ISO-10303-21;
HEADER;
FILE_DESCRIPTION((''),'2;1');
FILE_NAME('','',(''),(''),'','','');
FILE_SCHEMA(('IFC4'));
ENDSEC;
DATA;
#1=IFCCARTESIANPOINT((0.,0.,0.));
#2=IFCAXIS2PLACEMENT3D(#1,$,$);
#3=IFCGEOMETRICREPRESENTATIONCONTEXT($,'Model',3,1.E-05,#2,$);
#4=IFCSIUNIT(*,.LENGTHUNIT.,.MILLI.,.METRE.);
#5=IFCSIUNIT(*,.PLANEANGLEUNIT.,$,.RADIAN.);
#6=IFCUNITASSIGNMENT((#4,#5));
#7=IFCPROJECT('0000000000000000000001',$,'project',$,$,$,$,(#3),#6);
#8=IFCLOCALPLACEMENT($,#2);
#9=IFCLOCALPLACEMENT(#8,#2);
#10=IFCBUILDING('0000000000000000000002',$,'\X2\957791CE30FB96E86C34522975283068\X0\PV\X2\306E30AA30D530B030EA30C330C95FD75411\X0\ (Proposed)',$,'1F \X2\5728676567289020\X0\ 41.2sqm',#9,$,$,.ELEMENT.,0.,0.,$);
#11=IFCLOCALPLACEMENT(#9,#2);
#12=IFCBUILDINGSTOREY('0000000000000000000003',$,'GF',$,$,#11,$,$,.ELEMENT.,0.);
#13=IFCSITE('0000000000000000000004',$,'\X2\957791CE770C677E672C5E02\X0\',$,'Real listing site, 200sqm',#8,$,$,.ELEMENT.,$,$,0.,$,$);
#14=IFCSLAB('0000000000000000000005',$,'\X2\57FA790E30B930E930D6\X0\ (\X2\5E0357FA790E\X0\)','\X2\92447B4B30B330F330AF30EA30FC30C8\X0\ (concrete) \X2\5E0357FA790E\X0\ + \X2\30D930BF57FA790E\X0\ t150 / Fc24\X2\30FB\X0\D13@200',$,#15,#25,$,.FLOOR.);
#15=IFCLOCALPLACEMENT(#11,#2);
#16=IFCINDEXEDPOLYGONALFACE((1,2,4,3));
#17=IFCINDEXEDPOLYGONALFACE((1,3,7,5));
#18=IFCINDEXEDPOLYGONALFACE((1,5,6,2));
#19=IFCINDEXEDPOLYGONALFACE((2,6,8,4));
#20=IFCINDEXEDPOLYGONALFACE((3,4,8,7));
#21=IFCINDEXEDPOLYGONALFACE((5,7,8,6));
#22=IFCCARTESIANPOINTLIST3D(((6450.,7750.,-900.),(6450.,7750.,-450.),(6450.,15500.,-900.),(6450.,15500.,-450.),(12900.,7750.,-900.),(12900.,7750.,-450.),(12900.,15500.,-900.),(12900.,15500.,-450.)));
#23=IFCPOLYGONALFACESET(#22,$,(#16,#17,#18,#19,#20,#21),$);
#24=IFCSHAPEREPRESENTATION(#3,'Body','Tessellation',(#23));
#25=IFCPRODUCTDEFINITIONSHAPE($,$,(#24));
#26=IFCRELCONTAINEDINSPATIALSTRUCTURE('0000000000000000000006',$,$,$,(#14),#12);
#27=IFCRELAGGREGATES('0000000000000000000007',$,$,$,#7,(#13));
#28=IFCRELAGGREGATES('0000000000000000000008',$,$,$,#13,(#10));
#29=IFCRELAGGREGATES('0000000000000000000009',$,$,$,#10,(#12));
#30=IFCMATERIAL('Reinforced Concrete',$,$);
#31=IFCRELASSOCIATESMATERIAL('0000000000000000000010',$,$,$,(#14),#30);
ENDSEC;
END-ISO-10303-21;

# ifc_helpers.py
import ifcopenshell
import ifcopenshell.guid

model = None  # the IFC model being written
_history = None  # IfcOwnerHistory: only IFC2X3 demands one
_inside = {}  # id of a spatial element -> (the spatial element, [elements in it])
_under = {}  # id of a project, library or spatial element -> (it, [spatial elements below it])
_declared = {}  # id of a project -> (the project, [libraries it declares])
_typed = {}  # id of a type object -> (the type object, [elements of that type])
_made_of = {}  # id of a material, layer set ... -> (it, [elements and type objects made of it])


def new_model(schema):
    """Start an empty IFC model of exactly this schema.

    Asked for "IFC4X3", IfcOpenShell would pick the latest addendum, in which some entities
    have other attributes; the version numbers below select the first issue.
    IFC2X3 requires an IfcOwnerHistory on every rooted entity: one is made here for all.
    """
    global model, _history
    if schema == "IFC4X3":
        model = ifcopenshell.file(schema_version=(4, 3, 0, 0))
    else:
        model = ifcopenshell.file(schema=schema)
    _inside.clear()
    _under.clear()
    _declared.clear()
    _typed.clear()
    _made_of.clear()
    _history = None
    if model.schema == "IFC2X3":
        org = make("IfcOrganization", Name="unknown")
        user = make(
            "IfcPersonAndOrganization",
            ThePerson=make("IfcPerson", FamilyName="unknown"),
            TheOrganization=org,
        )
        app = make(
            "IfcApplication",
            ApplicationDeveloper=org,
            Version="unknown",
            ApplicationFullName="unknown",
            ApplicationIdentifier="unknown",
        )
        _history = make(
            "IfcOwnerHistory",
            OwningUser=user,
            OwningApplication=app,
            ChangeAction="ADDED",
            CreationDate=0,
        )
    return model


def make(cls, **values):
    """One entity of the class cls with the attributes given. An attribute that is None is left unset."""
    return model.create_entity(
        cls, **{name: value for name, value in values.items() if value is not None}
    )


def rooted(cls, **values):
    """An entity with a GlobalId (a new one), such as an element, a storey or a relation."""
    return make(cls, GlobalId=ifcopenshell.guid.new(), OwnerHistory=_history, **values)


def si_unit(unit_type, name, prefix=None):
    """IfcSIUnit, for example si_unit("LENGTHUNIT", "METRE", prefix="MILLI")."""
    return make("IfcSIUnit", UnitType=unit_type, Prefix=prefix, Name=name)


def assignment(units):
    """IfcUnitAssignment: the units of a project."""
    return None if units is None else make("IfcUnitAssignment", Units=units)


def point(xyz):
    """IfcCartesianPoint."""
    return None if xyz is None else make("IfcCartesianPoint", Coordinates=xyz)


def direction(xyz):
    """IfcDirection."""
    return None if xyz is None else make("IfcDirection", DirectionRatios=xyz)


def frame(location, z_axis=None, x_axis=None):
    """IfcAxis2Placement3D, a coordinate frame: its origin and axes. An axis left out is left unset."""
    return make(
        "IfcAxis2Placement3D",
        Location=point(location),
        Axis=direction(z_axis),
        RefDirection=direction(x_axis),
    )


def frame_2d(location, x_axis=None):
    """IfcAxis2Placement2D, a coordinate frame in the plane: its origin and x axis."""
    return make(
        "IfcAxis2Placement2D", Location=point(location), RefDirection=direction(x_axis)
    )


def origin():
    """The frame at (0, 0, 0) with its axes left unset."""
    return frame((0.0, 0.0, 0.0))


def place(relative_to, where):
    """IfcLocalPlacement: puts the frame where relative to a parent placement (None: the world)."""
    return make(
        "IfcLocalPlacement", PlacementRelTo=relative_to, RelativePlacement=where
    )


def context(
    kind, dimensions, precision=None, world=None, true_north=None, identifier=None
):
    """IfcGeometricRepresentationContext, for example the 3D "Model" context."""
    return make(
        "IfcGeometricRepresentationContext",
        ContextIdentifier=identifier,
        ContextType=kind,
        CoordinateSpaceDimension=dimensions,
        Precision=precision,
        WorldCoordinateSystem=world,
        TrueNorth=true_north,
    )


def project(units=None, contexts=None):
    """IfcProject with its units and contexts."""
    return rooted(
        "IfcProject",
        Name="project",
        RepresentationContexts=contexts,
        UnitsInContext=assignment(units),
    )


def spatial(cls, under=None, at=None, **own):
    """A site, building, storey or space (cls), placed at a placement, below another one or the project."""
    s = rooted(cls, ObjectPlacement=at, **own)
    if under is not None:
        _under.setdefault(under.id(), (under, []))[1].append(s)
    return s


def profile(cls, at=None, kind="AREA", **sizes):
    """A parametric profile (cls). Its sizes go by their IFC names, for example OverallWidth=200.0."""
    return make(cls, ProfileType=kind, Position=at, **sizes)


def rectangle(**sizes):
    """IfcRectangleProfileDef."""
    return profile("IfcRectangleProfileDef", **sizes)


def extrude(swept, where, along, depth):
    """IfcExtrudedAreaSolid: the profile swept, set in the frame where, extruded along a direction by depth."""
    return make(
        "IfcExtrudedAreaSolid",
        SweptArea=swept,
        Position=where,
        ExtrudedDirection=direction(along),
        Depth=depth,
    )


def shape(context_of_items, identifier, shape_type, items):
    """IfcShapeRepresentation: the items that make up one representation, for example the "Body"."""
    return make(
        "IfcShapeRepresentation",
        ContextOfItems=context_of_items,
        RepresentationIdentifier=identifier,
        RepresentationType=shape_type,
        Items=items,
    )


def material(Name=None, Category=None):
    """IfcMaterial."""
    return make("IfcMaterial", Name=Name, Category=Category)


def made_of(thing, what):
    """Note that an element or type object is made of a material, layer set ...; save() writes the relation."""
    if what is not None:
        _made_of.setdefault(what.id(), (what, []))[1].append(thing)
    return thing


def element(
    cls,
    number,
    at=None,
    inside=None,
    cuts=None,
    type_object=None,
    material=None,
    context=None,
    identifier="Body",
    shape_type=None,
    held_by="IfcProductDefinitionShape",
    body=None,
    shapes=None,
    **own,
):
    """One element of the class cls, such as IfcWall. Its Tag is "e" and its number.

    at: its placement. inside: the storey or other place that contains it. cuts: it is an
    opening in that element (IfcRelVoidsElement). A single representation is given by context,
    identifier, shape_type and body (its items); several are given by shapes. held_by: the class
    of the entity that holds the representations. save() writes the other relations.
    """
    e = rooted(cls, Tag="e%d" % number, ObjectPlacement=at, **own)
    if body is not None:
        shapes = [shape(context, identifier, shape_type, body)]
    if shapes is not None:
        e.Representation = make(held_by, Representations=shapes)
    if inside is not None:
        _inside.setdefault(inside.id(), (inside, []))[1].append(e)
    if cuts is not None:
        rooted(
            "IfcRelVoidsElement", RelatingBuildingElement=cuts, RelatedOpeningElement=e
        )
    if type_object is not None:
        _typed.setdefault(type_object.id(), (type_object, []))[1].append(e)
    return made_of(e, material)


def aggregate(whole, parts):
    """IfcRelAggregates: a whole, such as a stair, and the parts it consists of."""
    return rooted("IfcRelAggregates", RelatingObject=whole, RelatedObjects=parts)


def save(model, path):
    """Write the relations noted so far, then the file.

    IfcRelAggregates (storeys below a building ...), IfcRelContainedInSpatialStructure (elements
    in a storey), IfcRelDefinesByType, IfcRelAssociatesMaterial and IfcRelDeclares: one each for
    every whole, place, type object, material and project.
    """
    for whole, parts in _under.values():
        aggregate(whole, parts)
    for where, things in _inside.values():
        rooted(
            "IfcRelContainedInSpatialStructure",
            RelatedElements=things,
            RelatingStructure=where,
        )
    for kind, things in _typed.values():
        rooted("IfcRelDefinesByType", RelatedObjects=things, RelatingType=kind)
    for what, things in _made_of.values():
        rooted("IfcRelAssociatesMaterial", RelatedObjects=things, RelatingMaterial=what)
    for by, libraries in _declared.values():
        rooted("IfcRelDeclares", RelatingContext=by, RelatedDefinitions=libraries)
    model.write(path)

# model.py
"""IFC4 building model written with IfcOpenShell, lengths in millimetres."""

from ifc_helpers import new_model, si_unit, frame, frame_2d, origin, place, context, project, spatial, rectangle, extrude, material, element, save


model = new_model("IFC4")

# Units and contexts
model_context = context("Model", 3, precision=1e-05, world=origin())
ifc_project = project(units=[si_unit("LENGTHUNIT", "METRE", prefix="MILLI"), si_unit("PLANEANGLEUNIT", "RADIAN")], contexts=[model_context])

# Site, building, storey
site_placement = place(None, origin())
site = spatial("IfcSite", under=ifc_project, at=site_placement, Name="長野県松本市", ObjectType="Real listing site, 200sqm", CompositionType="ELEMENT", RefElevation=0.0)
building_placement = place(site_placement, origin())
building = spatial("IfcBuilding", under=site, at=building_placement, Name="長野・雨水利用とPVのオフグリッド志向 (Proposed)", ObjectType="1F 在来木造 41.2sqm", CompositionType="ELEMENT", ElevationOfRefHeight=0.0, ElevationOfTerrain=0.0)
storey_placement = place(building_placement, origin())
storey = spatial("IfcBuildingStorey", under=building, at=storey_placement, Name="GF", CompositionType="ELEMENT", Elevation=0.0)

# Slab
ifc_material_1 = material(Name="Reinforced Concrete")
slab_1_placement = place(storey_placement, frame((3225.0, 3875.0, -450.0)))
element("IfcSlab", 1, at=slab_1_placement, inside=storey, material=ifc_material_1, Name="基礎スラブ (布基礎)", Description="鉄筋コンクリート (concrete) 布基礎 + ベタ基礎 t150 / Fc24・D13@200", PredefinedType="FLOOR", context=model_context, shape_type="SweptSolid", body=[
    extrude(rectangle(XDim=6450.0, YDim=7750.0, at=frame_2d((3225.0, 3875.0))), frame((3225.0, 3875.0, -450.0)), (0.0, 0.0, 1.0), 450.0),
])

save(model, "model.ifc")
